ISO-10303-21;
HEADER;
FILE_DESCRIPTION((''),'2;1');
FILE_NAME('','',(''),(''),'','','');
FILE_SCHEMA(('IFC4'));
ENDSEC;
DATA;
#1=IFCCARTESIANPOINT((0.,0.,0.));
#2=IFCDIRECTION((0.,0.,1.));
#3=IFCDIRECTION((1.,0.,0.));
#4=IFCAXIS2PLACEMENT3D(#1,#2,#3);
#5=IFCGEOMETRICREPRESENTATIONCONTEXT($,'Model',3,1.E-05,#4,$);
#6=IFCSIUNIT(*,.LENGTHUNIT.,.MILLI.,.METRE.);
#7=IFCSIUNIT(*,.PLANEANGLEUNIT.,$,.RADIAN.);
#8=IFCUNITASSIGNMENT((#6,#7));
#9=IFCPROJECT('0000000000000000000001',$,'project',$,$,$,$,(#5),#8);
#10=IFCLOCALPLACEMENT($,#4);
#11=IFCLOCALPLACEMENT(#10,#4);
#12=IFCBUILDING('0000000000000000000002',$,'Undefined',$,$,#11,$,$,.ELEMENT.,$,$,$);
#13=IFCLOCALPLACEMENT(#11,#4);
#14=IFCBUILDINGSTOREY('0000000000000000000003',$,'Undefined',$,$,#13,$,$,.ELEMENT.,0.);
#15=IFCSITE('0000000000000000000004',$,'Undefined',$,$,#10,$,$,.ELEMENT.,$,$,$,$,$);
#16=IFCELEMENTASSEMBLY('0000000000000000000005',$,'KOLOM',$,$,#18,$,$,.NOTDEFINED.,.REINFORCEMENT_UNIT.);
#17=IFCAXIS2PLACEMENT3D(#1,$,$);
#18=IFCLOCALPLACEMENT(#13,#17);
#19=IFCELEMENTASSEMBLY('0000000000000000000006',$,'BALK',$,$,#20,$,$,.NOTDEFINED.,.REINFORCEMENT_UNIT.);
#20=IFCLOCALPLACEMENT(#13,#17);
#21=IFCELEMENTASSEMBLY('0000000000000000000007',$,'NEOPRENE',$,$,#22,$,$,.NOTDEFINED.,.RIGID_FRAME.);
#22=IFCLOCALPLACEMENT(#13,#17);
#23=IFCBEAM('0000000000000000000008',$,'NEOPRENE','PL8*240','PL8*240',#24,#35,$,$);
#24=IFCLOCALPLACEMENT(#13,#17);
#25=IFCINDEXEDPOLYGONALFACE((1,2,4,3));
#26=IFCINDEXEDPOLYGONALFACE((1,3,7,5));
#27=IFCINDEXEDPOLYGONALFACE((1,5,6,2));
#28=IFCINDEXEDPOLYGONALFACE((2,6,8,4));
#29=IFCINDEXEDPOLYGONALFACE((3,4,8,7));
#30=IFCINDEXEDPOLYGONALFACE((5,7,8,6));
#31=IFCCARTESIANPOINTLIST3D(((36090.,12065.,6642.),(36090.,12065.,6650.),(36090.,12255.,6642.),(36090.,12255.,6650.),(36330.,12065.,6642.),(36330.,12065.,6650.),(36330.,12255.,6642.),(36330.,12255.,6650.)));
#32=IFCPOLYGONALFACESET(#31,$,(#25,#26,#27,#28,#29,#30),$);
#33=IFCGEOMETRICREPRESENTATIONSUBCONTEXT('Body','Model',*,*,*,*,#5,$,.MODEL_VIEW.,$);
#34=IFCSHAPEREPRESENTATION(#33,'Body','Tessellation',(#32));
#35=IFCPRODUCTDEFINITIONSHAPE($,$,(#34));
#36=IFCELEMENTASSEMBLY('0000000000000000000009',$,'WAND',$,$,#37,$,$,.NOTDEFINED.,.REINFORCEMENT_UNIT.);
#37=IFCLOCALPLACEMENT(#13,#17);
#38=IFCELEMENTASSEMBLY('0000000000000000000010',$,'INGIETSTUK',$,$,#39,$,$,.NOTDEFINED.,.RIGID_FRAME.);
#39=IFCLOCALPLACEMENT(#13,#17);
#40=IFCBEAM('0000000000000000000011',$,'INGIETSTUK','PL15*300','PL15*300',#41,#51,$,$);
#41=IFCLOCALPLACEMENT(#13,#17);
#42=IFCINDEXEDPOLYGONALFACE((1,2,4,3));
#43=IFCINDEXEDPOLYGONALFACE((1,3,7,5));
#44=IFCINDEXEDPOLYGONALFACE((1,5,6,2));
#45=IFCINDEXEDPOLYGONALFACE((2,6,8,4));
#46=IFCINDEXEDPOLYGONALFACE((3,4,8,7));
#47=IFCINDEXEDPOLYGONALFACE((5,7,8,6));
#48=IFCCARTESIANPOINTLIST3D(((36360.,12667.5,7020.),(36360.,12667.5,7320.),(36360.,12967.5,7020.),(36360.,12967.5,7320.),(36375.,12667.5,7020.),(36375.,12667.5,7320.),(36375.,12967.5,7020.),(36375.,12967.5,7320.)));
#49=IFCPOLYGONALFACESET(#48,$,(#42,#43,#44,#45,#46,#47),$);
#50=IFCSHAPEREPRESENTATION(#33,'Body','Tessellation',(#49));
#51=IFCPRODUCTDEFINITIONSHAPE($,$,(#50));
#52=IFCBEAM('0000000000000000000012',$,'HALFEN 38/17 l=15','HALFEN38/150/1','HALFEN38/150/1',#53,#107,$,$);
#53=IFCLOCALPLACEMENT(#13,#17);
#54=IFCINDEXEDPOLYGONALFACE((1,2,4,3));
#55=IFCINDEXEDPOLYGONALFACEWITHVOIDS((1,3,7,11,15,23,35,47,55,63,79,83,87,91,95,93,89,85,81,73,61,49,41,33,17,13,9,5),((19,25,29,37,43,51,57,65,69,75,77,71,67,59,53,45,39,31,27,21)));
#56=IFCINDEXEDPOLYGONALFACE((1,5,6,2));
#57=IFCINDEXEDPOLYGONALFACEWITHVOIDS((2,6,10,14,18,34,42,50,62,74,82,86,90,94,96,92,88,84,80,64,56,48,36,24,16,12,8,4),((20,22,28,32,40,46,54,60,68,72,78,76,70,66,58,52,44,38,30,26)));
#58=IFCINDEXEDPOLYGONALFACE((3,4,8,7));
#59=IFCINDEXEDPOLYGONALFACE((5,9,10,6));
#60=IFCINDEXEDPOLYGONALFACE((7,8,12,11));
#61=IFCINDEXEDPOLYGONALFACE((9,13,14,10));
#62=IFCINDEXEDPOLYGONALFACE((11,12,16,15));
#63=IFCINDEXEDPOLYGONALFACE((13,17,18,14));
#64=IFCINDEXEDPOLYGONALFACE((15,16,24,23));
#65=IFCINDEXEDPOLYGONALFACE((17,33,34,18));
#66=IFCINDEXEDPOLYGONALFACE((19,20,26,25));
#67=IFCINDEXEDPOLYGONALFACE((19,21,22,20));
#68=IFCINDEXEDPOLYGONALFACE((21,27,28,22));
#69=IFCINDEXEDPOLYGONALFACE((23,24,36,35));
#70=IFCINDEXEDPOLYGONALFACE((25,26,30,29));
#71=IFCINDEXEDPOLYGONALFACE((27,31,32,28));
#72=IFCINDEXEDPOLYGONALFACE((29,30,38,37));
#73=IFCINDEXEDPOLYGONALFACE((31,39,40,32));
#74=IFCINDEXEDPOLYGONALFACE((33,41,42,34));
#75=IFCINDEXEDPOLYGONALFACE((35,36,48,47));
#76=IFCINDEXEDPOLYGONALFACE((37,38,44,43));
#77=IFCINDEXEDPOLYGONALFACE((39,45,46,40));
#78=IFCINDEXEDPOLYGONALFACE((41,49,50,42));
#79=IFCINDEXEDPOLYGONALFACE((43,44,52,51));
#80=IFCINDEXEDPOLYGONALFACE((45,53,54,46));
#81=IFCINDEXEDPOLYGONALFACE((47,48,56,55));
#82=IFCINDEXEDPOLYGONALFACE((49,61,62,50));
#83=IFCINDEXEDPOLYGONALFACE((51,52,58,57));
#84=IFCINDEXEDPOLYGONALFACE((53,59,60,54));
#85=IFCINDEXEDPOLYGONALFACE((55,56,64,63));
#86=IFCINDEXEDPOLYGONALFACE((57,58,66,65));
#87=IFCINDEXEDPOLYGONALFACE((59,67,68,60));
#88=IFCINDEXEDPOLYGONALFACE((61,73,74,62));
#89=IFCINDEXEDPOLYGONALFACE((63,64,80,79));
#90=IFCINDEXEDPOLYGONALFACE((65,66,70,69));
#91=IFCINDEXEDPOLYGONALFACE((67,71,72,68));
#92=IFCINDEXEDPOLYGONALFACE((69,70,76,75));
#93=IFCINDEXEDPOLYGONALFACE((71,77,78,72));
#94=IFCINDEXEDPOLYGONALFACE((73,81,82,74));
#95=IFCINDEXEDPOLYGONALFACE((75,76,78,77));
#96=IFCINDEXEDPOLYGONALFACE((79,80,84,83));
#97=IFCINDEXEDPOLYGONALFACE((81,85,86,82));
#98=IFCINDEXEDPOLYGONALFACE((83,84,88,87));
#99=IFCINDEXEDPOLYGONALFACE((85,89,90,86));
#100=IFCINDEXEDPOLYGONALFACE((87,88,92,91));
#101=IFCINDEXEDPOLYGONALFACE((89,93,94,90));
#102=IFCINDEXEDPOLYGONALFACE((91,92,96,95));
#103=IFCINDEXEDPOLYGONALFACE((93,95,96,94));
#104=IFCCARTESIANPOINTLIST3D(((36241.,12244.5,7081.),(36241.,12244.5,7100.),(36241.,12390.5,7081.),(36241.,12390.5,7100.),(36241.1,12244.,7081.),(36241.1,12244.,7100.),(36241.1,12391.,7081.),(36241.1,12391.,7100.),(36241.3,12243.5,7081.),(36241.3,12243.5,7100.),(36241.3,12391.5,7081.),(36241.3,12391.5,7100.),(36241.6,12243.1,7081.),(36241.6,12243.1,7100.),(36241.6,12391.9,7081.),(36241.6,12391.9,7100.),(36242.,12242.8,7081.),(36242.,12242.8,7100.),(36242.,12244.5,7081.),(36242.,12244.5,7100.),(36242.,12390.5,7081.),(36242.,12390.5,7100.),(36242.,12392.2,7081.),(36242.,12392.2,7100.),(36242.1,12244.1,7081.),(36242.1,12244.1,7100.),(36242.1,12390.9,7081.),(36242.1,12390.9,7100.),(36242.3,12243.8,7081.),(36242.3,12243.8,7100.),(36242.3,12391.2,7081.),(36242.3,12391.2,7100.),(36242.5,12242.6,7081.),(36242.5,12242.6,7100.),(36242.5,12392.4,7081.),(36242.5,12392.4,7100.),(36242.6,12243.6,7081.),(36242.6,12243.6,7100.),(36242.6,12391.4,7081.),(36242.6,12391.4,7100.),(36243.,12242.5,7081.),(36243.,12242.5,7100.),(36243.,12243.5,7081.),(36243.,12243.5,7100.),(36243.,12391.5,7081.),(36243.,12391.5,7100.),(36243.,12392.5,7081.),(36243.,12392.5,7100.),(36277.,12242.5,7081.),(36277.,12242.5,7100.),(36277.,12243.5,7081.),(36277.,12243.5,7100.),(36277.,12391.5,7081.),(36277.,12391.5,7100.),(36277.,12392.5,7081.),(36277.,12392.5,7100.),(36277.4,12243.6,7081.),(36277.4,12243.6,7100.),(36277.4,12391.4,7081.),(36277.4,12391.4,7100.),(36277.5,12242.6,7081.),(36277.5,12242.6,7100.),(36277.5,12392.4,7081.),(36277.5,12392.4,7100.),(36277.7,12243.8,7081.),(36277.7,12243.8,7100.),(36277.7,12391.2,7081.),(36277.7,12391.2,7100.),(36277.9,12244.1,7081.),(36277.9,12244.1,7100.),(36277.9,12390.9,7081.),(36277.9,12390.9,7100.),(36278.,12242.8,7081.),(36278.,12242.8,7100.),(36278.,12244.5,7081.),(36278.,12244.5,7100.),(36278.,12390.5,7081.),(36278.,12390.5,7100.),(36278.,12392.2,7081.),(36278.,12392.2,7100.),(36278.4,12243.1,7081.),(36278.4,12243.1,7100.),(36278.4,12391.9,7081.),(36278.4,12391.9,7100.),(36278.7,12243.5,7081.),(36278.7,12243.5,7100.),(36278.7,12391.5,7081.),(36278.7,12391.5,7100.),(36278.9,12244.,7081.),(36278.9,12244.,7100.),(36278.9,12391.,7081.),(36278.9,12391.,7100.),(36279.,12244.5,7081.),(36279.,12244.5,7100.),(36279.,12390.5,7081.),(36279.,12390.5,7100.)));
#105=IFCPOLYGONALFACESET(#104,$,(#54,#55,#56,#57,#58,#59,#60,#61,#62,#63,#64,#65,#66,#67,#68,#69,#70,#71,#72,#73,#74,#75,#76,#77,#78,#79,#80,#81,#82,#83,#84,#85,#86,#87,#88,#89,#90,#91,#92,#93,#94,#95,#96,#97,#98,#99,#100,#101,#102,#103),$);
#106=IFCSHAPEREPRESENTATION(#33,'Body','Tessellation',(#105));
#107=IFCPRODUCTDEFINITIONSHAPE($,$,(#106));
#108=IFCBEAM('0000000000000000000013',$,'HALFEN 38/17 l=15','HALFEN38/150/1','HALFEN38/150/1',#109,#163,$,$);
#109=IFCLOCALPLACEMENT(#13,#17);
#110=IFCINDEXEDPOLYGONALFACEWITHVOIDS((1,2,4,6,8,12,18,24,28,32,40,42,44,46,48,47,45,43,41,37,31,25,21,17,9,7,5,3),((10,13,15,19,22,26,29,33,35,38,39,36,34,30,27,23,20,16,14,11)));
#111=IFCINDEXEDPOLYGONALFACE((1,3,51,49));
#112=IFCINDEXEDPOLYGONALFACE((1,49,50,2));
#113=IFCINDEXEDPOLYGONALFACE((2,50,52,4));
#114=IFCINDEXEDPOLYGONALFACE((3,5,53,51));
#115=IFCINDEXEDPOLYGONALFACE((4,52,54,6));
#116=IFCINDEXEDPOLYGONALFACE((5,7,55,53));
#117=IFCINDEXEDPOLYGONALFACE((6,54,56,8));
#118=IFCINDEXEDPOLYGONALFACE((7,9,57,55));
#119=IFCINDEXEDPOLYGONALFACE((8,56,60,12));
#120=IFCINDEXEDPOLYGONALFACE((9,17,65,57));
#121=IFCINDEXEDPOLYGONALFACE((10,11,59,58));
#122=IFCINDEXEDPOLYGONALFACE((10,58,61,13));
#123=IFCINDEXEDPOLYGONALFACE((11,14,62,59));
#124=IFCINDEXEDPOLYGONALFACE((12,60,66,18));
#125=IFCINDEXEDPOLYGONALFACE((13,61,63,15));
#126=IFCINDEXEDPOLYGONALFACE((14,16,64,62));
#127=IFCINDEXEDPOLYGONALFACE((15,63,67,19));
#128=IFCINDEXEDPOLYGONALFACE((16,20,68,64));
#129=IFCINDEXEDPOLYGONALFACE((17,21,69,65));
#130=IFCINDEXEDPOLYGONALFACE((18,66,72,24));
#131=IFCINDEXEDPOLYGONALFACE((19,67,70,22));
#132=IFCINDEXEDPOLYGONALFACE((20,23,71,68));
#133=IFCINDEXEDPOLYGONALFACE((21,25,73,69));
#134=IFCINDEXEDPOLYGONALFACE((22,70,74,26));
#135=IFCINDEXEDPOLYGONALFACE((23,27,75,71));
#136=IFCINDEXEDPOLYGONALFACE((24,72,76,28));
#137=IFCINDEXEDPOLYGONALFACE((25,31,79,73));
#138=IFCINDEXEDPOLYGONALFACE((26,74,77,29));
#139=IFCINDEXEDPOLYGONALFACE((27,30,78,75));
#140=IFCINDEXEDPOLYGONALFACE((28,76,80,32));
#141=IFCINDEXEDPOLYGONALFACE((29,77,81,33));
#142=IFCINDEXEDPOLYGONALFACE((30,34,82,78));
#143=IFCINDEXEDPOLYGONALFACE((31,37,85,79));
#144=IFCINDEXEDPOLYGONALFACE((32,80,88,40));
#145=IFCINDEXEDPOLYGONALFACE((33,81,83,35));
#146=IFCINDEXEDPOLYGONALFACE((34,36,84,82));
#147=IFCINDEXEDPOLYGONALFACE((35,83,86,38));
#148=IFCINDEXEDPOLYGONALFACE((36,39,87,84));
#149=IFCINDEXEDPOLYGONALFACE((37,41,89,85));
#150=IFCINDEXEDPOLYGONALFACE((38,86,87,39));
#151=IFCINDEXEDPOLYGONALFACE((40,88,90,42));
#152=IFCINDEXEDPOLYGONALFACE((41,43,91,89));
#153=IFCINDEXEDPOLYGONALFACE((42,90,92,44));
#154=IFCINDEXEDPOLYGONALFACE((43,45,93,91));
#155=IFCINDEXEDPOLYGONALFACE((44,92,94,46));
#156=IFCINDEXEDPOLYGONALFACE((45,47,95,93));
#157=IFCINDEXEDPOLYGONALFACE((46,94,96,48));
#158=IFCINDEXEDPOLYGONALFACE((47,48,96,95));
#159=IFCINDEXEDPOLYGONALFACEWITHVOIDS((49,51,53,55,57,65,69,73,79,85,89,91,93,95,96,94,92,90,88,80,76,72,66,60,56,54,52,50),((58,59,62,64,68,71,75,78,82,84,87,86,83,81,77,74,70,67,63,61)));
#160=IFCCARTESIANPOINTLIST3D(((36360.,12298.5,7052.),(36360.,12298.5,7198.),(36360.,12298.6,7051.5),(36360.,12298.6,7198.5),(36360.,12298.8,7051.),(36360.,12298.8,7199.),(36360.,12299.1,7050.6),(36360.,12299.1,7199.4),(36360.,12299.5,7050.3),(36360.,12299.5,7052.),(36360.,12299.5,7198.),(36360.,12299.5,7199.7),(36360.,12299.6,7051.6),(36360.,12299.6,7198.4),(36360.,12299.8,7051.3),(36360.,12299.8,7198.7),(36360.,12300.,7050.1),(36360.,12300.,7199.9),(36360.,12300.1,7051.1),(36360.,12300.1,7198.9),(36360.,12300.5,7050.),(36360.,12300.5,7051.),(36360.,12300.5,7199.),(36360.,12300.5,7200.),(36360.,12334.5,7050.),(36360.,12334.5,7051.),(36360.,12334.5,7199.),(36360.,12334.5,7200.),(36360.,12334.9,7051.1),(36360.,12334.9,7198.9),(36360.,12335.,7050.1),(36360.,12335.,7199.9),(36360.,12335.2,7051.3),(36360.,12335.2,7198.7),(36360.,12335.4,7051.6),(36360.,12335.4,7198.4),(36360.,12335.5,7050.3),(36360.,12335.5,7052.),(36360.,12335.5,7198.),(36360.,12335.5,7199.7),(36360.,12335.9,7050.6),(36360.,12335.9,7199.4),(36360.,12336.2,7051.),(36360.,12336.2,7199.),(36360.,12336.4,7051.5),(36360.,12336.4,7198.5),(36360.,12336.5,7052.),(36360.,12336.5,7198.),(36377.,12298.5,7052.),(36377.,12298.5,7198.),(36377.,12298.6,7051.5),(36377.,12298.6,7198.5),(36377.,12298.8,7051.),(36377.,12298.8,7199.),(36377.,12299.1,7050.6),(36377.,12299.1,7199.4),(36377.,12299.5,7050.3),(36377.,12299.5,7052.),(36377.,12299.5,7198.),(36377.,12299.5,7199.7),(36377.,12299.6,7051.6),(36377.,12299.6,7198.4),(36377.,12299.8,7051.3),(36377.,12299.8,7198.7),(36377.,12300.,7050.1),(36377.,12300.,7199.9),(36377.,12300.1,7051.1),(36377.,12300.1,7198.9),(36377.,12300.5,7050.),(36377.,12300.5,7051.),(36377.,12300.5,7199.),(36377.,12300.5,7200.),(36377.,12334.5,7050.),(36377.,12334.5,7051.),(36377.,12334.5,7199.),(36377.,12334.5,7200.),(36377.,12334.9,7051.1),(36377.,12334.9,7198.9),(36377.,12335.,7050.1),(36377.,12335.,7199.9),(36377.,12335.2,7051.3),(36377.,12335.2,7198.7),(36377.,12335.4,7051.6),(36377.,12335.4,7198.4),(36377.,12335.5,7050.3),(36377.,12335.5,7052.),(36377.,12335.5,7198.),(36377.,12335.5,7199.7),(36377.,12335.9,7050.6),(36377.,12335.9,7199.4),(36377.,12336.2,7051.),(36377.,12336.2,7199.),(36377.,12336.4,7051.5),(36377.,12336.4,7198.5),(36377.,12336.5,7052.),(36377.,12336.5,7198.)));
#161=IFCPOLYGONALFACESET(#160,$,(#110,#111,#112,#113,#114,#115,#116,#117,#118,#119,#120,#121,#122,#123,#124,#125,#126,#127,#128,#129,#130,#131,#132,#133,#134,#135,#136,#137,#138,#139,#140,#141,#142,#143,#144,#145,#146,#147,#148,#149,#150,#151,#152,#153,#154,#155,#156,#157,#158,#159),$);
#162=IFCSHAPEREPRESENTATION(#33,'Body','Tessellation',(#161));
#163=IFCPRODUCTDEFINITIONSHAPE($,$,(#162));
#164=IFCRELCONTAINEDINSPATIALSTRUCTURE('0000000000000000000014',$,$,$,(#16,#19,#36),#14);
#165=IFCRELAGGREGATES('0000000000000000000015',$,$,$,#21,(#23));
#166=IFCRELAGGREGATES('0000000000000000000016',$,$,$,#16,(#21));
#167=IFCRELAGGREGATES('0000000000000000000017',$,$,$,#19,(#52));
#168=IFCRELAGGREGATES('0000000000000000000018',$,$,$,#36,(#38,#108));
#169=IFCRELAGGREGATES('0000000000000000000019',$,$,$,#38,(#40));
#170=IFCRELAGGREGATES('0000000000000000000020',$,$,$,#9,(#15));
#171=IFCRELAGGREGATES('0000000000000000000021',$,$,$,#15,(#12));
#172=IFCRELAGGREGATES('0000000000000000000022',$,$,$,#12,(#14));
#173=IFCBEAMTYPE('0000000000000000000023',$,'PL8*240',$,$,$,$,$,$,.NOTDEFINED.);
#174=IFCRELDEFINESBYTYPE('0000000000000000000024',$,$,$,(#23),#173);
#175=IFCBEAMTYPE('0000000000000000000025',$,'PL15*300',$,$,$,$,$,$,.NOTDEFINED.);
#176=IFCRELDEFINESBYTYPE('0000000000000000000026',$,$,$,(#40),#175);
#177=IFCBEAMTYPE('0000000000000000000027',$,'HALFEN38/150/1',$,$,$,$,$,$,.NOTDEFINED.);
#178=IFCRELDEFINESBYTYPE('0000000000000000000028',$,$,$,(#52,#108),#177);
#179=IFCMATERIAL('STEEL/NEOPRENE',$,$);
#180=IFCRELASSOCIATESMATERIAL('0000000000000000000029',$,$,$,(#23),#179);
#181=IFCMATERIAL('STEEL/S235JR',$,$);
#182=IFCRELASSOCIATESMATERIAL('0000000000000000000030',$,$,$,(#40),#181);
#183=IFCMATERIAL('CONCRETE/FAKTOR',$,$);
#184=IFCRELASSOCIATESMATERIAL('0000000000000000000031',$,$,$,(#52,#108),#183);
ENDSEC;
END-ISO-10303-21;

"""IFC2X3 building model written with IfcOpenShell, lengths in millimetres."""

from ifc_helpers import new_model, si_unit, frame, frame_2d, origin_with_axes, place, context, subcontext, project, spatial, rectangle, hollow_rectangle, extrude, material, type_object, element, aggregate, save


model = new_model("IFC2X3")

# Units and contexts
model_context = context("Model", 3, precision=1e-05, world=origin_with_axes())
body_context = subcontext(model_context, "Body", "Model", "MODEL_VIEW")
ifc_project = project(units=[si_unit("LENGTHUNIT", "METRE", prefix="MILLI"), si_unit("PLANEANGLEUNIT", "RADIAN")], contexts=[model_context])

# Site, building, storey
site_placement = place(None, origin_with_axes())
site = spatial("IfcSite", under=ifc_project, at=site_placement, Name="Undefined", CompositionType="ELEMENT")
building_placement = place(site_placement, origin_with_axes())
building = spatial("IfcBuilding", under=site, at=building_placement, Name="Undefined", CompositionType="ELEMENT")
storey_placement = place(building_placement, origin_with_axes())
storey = spatial("IfcBuildingStorey", under=building, at=storey_placement, Name="Undefined", CompositionType="ELEMENT", Elevation=0.0)

# Element assembly
assembly_1_placement = place(storey_placement, origin_with_axes())
assembly_1 = element("IfcElementAssembly", 1, at=assembly_1_placement, inside=storey, Name="KOLOM", AssemblyPlace="NOTDEFINED", PredefinedType="REINFORCEMENT_UNIT")
ifc_material_1 = material(Name="CONCRETE/FAKTOR")

# Element assemblies, beam
assembly_2_placement = place(storey_placement, origin_with_axes())
assembly_2 = element("IfcElementAssembly", 2, at=assembly_2_placement, inside=storey, Name="BALK", AssemblyPlace="NOTDEFINED", PredefinedType="REINFORCEMENT_UNIT")
assembly_3_placement = place(assembly_1_placement, origin_with_axes())
assembly_3 = element("IfcElementAssembly", 3, at=assembly_3_placement, Name="NEOPRENE", AssemblyPlace="NOTDEFINED", PredefinedType="RIGID_FRAME")
ifc_material_2 = material(Name="STEEL/NEOPRENE")
beam_type_1 = type_object("IfcBeamType", Name="PL8*240", PredefinedType="NOTDEFINED")
beam_1_placement = place(assembly_3_placement, frame((36210.0, 12255.0, 6646.0), z_axis=(1.0, 0.0, 0.0), x_axis=(0.0, -1.0, 0.0)))
beam_1 = element("IfcBeam", 4, at=beam_1_placement, type_object=beam_type_1, material=ifc_material_2, Name="NEOPRENE", Description="PL8*240", ObjectType="PL8*240", context=body_context, shape_type="SweptSolid", body=[
    extrude(rectangle(XDim=8.0, YDim=240.0, at=frame_2d((0.0, 0.0), x_axis=(1.0, 0.0))), frame((190.0, 0.0, 0.0), z_axis=(-1.0, 0.0, 0.0), x_axis=(0.0, -1.0, 0.0)), (0.0, 0.0, 1.0), 190.0),
])
aggregate(assembly_3, [beam_1])

# Element assemblies, beam
assembly_4_placement = place(storey_placement, origin_with_axes())
assembly_4 = element("IfcElementAssembly", 5, at=assembly_4_placement, inside=storey, Name="WAND", AssemblyPlace="NOTDEFINED", PredefinedType="REINFORCEMENT_UNIT")
assembly_5_placement = place(assembly_4_placement, origin_with_axes())
assembly_5 = element("IfcElementAssembly", 6, at=assembly_5_placement, Name="INGIETSTUK", AssemblyPlace="NOTDEFINED", PredefinedType="RIGID_FRAME")
ifc_material_3 = material(Name="STEEL/S235JR")
beam_type_2 = type_object("IfcBeamType", Name="PL15*300", PredefinedType="NOTDEFINED")
beam_2_placement = place(assembly_5_placement, frame((36367.5, 12667.5, 7170.0), z_axis=(0.0, 0.0, 1.0), x_axis=(0.0, 1.0, 0.0)))
beam_2 = element("IfcBeam", 7, at=beam_2_placement, type_object=beam_type_2, material=ifc_material_3, Name="INGIETSTUK", Description="PL15*300", ObjectType="PL15*300", context=body_context, shape_type="SweptSolid", body=[
    extrude(rectangle(XDim=15.0, YDim=300.0, at=frame_2d((0.0, 0.0), x_axis=(1.0, 0.0))), frame((300.0, 0.0, 0.0), z_axis=(-1.0, 0.0, 0.0), x_axis=(0.0, -1.0, 0.0)), (0.0, 0.0, 1.0), 300.0),
])

# Beams
beam_type_3 = type_object("IfcBeamType", Name="HALFEN38/150/1", PredefinedType="NOTDEFINED")
beam_3_placement = place(assembly_2_placement, frame((36260.0, 12317.5, 7100.0), z_axis=(1.0, 0.0, 0.0), x_axis=(0.0, 0.0, -1.0)))
beam_3 = element("IfcBeam", 8, at=beam_3_placement, type_object=beam_type_3, material=ifc_material_1, Name="HALFEN 38/17 l=15", Description="HALFEN38/150/1", ObjectType="HALFEN38/150/1", context=body_context, shape_type="SweptSolid", body=[
    extrude(hollow_rectangle(XDim=150.0, YDim=38.0, WallThickness=1.0, InnerFilletRadius=1.0, OuterFilletRadius=2.0, at=frame_2d((0.0, 0.0), x_axis=(1.0, 0.0))), frame((19.0, 0.0, 0.0), z_axis=(-1.0, 0.0, 0.0), x_axis=(0.0, -1.0, 0.0)), (0.0, 0.0, 1.0), 19.0),
])
beam_4_placement = place(assembly_4_placement, frame((36360.0, 12317.5, 7125.0), z_axis=(0.0, -1.0, 0.0), x_axis=(1.0, 0.0, 0.0)))
beam_4 = element("IfcBeam", 9, at=beam_4_placement, type_object=beam_type_3, material=ifc_material_1, Name="HALFEN 38/17 l=15", Description="HALFEN38/150/1", ObjectType="HALFEN38/150/1", context=body_context, shape_type="SweptSolid", body=[
    extrude(hollow_rectangle(XDim=150.0, YDim=38.0, WallThickness=1.0, InnerFilletRadius=1.0, OuterFilletRadius=2.0, at=frame_2d((0.0, 0.0), x_axis=(1.0, 0.0))), frame((17.0, 0.0, 0.0), z_axis=(-1.0, 0.0, 0.0), x_axis=(0.0, -1.0, 0.0)), (0.0, 0.0, 1.0), 17.0),
])
aggregate(assembly_1, [assembly_3])

aggregate(assembly_2, [beam_3])
aggregate(assembly_4, [assembly_5, beam_4])

aggregate(assembly_5, [beam_2])

save(model, "model.ifc")
